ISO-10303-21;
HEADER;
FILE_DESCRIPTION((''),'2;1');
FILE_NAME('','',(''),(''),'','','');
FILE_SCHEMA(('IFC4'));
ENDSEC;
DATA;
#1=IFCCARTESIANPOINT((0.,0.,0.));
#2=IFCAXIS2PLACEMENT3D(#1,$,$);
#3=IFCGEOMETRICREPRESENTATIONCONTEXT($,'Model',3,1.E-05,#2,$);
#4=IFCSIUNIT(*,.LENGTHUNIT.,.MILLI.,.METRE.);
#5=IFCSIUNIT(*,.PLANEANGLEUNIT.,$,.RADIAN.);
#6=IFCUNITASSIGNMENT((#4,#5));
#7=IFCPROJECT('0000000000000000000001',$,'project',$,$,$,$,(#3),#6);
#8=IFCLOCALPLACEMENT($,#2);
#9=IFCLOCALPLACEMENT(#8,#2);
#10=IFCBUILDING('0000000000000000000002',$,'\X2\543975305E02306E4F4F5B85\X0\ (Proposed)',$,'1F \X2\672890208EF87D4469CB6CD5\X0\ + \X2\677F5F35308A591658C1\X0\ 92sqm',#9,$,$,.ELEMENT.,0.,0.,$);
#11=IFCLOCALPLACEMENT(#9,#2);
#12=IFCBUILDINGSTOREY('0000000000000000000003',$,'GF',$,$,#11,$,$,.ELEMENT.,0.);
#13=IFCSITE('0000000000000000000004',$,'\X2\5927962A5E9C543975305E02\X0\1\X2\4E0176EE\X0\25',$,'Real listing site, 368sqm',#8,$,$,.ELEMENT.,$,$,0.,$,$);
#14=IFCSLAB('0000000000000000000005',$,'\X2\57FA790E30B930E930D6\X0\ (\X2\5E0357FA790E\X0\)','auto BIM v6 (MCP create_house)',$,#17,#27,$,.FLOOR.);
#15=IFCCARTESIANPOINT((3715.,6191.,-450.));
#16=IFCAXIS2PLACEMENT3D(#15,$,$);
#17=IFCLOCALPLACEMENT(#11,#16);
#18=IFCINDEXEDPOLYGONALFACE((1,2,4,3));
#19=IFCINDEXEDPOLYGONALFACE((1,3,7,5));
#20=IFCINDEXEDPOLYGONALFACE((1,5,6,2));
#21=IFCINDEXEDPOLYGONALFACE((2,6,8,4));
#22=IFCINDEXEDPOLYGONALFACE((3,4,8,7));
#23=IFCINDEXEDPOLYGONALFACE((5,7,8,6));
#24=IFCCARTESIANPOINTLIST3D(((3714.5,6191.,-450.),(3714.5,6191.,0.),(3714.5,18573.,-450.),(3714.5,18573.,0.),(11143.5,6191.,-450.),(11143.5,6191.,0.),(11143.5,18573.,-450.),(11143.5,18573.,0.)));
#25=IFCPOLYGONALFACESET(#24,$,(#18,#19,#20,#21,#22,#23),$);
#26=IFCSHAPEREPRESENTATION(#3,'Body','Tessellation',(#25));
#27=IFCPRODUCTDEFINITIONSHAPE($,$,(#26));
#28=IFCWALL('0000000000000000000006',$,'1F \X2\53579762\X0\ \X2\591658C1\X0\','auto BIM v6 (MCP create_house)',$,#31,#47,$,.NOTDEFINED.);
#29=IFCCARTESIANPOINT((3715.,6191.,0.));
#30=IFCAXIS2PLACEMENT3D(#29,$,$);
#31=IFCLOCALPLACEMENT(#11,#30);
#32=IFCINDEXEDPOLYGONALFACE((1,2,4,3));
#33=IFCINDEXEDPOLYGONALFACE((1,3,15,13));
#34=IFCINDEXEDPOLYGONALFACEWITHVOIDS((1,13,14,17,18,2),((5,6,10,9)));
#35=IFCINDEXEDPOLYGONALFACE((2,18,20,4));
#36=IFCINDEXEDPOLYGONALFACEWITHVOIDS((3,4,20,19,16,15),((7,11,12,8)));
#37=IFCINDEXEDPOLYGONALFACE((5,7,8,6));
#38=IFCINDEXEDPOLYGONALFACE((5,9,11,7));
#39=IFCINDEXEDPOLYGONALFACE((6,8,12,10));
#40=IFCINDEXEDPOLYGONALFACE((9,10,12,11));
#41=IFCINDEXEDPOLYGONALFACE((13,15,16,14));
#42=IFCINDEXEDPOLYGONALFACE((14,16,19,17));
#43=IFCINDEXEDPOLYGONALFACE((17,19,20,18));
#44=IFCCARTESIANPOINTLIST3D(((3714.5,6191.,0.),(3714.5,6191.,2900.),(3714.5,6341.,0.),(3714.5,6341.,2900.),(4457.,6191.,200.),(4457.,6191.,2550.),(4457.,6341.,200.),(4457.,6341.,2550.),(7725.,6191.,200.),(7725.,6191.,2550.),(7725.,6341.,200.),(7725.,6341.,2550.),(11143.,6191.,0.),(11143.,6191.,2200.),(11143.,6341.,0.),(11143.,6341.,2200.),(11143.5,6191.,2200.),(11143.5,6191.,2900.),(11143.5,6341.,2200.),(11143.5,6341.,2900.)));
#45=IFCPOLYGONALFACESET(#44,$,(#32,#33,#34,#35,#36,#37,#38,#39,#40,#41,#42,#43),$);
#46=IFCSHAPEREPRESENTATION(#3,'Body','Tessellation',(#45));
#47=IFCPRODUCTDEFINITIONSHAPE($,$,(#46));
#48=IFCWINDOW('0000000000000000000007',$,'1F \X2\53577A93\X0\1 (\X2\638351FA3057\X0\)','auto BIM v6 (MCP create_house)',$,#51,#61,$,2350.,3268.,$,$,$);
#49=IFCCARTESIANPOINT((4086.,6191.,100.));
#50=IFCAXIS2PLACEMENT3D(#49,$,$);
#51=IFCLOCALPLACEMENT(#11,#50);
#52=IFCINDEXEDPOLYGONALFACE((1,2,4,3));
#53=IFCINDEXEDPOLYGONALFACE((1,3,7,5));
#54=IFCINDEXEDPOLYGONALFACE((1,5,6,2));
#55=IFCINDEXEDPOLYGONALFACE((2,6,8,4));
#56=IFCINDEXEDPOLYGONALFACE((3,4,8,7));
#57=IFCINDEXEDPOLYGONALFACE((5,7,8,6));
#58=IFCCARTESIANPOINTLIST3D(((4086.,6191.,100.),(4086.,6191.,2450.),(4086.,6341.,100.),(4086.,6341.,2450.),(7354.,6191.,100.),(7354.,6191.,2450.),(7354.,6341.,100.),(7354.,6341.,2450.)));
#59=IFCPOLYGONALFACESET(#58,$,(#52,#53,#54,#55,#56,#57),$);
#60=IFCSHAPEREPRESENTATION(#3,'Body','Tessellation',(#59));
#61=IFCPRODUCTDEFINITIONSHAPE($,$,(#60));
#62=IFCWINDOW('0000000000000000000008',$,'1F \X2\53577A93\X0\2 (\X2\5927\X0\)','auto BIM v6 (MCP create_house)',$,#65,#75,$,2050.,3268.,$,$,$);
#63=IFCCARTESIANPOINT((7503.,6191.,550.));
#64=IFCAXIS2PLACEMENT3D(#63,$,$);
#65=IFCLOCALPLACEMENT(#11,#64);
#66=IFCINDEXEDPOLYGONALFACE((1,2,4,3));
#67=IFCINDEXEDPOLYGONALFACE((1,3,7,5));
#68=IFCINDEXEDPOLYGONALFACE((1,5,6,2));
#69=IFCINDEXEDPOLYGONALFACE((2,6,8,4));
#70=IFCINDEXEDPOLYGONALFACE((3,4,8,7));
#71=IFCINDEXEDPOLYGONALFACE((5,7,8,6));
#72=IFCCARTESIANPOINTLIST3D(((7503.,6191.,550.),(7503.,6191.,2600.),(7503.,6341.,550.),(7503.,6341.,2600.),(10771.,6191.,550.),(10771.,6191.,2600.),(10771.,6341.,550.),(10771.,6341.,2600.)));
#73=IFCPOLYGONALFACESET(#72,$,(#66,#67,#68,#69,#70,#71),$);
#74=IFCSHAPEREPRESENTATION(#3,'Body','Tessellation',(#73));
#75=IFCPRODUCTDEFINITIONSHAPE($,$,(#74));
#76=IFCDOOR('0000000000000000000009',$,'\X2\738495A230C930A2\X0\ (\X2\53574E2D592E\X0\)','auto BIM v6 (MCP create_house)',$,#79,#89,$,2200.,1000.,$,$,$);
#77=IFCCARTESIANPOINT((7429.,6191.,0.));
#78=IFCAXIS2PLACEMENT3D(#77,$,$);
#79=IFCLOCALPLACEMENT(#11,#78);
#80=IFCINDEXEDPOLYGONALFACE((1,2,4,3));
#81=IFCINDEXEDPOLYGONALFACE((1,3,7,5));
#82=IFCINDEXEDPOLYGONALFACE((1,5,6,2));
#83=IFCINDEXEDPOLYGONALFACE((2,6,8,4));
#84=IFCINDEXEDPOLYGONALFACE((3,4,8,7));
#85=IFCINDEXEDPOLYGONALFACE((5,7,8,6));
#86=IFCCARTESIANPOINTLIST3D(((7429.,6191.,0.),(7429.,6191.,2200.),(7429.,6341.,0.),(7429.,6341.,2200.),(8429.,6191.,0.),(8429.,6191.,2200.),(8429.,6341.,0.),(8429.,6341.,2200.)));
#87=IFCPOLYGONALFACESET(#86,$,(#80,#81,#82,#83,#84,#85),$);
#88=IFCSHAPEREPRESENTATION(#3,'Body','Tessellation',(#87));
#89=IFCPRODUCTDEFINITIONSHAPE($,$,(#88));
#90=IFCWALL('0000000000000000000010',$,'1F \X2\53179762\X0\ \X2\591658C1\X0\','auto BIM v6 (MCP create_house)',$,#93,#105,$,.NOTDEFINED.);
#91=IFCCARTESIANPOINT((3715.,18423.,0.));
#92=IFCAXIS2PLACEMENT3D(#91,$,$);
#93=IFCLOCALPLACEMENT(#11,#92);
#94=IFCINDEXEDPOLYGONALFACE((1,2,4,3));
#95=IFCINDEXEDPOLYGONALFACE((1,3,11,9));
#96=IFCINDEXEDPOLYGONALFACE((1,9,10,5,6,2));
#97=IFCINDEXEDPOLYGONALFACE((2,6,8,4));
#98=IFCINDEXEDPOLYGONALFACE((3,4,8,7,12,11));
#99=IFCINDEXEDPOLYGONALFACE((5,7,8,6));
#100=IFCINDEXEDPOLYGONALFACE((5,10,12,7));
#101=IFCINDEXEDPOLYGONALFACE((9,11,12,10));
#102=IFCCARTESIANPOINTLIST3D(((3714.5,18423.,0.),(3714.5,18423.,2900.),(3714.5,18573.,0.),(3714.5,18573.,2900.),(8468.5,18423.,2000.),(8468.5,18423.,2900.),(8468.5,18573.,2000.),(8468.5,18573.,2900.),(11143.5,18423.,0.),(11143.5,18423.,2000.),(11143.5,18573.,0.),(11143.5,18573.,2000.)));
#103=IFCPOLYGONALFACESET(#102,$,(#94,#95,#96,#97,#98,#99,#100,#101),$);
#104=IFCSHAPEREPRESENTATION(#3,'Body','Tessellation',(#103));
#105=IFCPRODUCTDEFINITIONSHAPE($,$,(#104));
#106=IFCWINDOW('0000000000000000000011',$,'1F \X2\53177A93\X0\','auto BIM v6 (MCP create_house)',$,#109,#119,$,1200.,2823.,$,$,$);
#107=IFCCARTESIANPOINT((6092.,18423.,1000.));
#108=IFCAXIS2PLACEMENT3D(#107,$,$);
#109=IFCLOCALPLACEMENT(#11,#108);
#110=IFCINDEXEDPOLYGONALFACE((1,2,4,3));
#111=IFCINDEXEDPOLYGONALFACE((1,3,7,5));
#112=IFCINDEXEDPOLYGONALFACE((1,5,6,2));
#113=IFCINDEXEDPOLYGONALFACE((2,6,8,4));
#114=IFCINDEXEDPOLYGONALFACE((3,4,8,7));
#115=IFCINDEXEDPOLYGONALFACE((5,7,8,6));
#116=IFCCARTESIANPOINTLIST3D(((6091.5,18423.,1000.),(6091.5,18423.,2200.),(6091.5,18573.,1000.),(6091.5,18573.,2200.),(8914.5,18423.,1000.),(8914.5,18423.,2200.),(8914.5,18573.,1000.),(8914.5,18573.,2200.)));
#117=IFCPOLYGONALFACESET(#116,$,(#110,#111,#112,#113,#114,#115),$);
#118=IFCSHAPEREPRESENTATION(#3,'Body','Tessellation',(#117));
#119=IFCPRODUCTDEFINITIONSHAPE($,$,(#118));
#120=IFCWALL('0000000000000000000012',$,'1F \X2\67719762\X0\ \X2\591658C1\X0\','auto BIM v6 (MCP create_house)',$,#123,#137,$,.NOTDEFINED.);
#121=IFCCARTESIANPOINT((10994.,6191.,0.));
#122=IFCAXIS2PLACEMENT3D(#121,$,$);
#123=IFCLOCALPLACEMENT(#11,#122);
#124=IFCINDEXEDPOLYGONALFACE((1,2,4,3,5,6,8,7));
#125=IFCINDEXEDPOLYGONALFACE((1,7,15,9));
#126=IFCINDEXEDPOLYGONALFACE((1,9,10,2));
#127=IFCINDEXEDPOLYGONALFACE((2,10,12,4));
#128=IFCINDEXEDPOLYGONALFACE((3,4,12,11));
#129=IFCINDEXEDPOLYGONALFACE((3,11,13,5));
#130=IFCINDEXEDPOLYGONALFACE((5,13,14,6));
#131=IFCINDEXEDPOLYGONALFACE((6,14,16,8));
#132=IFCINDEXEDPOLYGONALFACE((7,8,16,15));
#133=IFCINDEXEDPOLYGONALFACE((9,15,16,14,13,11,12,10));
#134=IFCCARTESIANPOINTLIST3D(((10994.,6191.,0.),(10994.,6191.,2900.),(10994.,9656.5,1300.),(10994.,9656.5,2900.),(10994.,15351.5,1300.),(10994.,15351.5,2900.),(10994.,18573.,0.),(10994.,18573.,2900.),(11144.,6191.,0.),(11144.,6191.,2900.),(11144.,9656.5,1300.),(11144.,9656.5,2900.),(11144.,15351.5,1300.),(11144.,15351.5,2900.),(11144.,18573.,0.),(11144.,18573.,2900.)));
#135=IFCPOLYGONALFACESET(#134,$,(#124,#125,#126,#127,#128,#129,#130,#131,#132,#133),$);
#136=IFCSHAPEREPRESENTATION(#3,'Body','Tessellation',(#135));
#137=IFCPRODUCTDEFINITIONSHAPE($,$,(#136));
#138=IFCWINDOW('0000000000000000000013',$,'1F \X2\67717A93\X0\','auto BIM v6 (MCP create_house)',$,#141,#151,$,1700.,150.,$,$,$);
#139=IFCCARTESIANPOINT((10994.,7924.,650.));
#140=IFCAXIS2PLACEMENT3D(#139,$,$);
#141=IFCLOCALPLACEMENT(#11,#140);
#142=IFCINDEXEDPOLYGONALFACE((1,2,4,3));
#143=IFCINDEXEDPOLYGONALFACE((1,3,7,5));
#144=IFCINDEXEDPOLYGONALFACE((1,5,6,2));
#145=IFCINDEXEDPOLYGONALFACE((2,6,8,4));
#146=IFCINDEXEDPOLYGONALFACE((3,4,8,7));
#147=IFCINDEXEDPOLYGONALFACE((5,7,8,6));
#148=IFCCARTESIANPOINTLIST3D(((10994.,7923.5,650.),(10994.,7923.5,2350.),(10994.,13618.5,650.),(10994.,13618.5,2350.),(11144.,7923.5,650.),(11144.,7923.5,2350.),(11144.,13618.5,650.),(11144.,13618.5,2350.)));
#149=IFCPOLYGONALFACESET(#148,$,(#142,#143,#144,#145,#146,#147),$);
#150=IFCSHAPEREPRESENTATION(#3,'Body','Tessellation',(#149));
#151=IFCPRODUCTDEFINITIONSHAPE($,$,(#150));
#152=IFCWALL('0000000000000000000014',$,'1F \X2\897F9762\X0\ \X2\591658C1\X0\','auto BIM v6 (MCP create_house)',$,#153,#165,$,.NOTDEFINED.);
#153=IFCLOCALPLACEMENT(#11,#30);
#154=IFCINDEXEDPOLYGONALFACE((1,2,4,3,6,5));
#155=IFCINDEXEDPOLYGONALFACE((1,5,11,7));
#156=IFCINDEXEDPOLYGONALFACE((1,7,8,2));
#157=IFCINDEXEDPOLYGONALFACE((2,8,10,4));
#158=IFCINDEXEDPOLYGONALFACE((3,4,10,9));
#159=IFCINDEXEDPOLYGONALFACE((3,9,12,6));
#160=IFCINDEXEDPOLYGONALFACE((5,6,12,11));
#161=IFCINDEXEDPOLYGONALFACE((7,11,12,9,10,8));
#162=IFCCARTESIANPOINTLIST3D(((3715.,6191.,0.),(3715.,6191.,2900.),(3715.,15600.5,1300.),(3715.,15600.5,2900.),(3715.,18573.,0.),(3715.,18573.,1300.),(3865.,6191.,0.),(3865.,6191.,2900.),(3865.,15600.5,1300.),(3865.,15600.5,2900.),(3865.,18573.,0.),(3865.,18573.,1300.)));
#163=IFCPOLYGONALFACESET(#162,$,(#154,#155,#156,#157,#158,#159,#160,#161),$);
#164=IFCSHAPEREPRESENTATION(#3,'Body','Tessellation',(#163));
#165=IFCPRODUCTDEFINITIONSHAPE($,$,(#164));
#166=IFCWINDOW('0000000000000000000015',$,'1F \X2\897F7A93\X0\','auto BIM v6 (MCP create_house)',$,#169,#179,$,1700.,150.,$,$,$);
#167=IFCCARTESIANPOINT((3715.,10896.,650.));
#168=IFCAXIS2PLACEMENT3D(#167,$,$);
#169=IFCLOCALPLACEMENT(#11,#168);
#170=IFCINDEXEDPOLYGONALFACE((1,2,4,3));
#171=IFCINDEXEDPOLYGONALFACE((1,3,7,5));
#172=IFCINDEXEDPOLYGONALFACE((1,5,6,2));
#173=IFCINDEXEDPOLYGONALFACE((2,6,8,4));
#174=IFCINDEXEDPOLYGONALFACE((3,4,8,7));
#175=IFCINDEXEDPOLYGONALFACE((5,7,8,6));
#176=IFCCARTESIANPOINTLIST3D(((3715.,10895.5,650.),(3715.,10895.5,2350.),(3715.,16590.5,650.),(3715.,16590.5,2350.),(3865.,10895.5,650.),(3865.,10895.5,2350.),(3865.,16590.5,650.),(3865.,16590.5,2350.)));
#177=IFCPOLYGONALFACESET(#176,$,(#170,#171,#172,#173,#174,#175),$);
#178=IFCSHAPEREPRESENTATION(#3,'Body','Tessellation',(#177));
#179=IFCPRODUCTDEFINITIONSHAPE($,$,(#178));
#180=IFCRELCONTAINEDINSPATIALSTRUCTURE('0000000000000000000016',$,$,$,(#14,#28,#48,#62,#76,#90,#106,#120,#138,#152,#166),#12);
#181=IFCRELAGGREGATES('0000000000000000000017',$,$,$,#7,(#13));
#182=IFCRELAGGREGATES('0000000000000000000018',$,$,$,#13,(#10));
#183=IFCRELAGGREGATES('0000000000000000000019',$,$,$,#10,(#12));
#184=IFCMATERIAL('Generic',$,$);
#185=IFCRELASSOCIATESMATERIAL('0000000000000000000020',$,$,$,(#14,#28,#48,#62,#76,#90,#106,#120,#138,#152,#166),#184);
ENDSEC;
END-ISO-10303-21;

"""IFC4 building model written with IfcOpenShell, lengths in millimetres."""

from ifc_helpers import new_model, si_unit, frame, frame_2d, origin, place, context, project, spatial, rectangle, extrude, material, element, fill, save


model = new_model("IFC4")

# Units and contexts
model_context = context("Model", 3, precision=1e-05, world=origin())
ifc_project = project(units=[si_unit("LENGTHUNIT", "METRE", prefix="MILLI"), si_unit("PLANEANGLEUNIT", "RADIAN")], contexts=[model_context])

# Site, building, storey
site_placement = place(None, origin())
site = spatial("IfcSite", under=ifc_project, at=site_placement, Name="大阪府吹田市1丁目25", ObjectType="Real listing site, 368sqm", CompositionType="ELEMENT", RefElevation=0.0)
building_placement = place(site_placement, origin())
building = spatial("IfcBuilding", under=site, at=building_placement, Name="吹田市の住宅 (Proposed)", ObjectType="1F 木造軸組構法 + 板張り外壁 92sqm", CompositionType="ELEMENT", ElevationOfRefHeight=0.0, ElevationOfTerrain=0.0)
storey_placement = place(building_placement, origin())
storey = spatial("IfcBuildingStorey", under=building, at=storey_placement, Name="GF", CompositionType="ELEMENT", Elevation=0.0)

# Slab
ifc_material = material(Name="Generic")
slab_1_placement = place(storey_placement, frame((3715.0, 6191.0, -450.0)))
element("IfcSlab", 1, at=slab_1_placement, inside=storey, material=ifc_material, Name="基礎スラブ (布基礎)", Description="auto BIM v6 (MCP create_house)", PredefinedType="FLOOR", context=model_context, shape_type="SweptSolid", body=[
    extrude(rectangle(XDim=7429.0, YDim=12382.0, at=frame_2d((3714.0, 6191.0))), frame((3715.0, 6191.0, -450.0)), (0.0, 0.0, 1.0), 450.0),
])

# Wall, openings, windows, door
wall_1_placement = place(storey_placement, frame((3715.0, 6191.0, 0.0)))
wall_1 = element("IfcWall", 2, at=wall_1_placement, inside=storey, material=ifc_material, Name="1F 南面 外壁", Description="auto BIM v6 (MCP create_house)", PredefinedType="NOTDEFINED", context=model_context, shape_type="SweptSolid", body=[
    extrude(rectangle(XDim=7429.0, YDim=150.0, at=frame_2d((3714.0, 75.0))), frame((3715.0, 6191.0, 0.0)), (0.0, 0.0, 1.0), 2900.0),
])
opening_1_placement = place(storey_placement, frame((4086.0, 6191.0, 100.0)))
opening_1 = element("IfcOpeningElement", 3, at=opening_1_placement, cuts=wall_1, PredefinedType="NOTDEFINED", context=model_context, shape_type="SweptSolid", body=[
    extrude(rectangle(XDim=3268.0, YDim=150.0, at=frame_2d((1634.0, 75.0))), frame((4086.0, 6191.0, 100.0)), (0.0, 0.0, 1.0), 2350.0),
])
opening_2_placement = place(storey_placement, frame((7503.0, 6191.0, 550.0)))
opening_2 = element("IfcOpeningElement", 4, at=opening_2_placement, cuts=wall_1, PredefinedType="NOTDEFINED", context=model_context, shape_type="SweptSolid", body=[
    extrude(rectangle(XDim=3268.0, YDim=150.0, at=frame_2d((1634.0, 75.0))), frame((7503.0, 6191.0, 550.0)), (0.0, 0.0, 1.0), 2050.0),
])
opening_3_placement = place(storey_placement, frame((7429.0, 6191.0, 0.0)))
opening_3 = element("IfcOpeningElement", 5, at=opening_3_placement, cuts=wall_1, PredefinedType="NOTDEFINED", context=model_context, shape_type="SweptSolid", body=[
    extrude(rectangle(XDim=1000.0, YDim=150.0, at=frame_2d((500.0, 75.0))), frame((7429.0, 6191.0, 0.0)), (0.0, 0.0, 1.0), 2200.0),
])
window_1_placement = place(storey_placement, frame((4086.0, 6191.0, 100.0)))
window_1 = element("IfcWindow", 6, at=window_1_placement, inside=storey, material=ifc_material, Name="1F 南窓1 (掃出し)", Description="auto BIM v6 (MCP create_house)", OverallHeight=2350.0, OverallWidth=3268.0, context=model_context, shape_type="SweptSolid", body=[
    extrude(rectangle(XDim=3268.0, YDim=150.0, at=frame_2d((1634.0, 75.0))), frame((4086.0, 6191.0, 100.0)), (0.0, 0.0, 1.0), 2350.0),
])
fill(opening_1, window_1)
window_2_placement = place(storey_placement, frame((7503.0, 6191.0, 550.0)))
window_2 = element("IfcWindow", 7, at=window_2_placement, inside=storey, material=ifc_material, Name="1F 南窓2 (大)", Description="auto BIM v6 (MCP create_house)", OverallHeight=2050.0, OverallWidth=3268.0, context=model_context, shape_type="SweptSolid", body=[
    extrude(rectangle(XDim=3268.0, YDim=150.0, at=frame_2d((1634.0, 75.0))), frame((7503.0, 6191.0, 550.0)), (0.0, 0.0, 1.0), 2050.0),
])
fill(opening_2, window_2)
door_placement = place(storey_placement, frame((7429.0, 6191.0, 0.0)))
door = element("IfcDoor", 8, at=door_placement, inside=storey, material=ifc_material, Name="玄関ドア (南中央)", Description="auto BIM v6 (MCP create_house)", OverallHeight=2200.0, OverallWidth=1000.0, context=model_context, shape_type="SweptSolid", body=[
    extrude(rectangle(XDim=1000.0, YDim=150.0, at=frame_2d((500.0, 75.0))), frame((7429.0, 6191.0, 0.0)), (0.0, 0.0, 1.0), 2200.0),
])
fill(opening_3, door)

# Walls, openings, windows
wall_2_placement = place(storey_placement, frame((3715.0, 18423.0, 0.0)))
wall_2 = element("IfcWall", 9, at=wall_2_placement, inside=storey, material=ifc_material, Name="1F 北面 外壁", Description="auto BIM v6 (MCP create_house)", PredefinedType="NOTDEFINED", context=model_context, shape_type="SweptSolid", body=[
    extrude(rectangle(XDim=7429.0, YDim=150.0, at=frame_2d((3714.0, 75.0))), frame((3715.0, 18423.0, 0.0)), (0.0, 0.0, 1.0), 2900.0),
])
opening_4_placement = place(storey_placement, frame((6092.0, 18423.0, 1000.0)))
opening_4 = element("IfcOpeningElement", 10, at=opening_4_placement, cuts=wall_2, PredefinedType="NOTDEFINED", context=model_context, shape_type="SweptSolid", body=[
    extrude(rectangle(XDim=2823.0, YDim=150.0, at=frame_2d((1411.0, 75.0))), frame((6092.0, 18423.0, 1000.0)), (0.0, 0.0, 1.0), 1200.0),
])
window_3_placement = place(storey_placement, frame((6092.0, 18423.0, 1000.0)))
window_3 = element("IfcWindow", 11, at=window_3_placement, inside=storey, material=ifc_material, Name="1F 北窓", Description="auto BIM v6 (MCP create_house)", OverallHeight=1200.0, OverallWidth=2823.0, context=model_context, shape_type="SweptSolid", body=[
    extrude(rectangle(XDim=2823.0, YDim=150.0, at=frame_2d((1411.0, 75.0))), frame((6092.0, 18423.0, 1000.0)), (0.0, 0.0, 1.0), 1200.0),
])
fill(opening_4, window_3)
wall_3_placement = place(storey_placement, frame((10994.0, 6191.0, 0.0)))
wall_3 = element("IfcWall", 12, at=wall_3_placement, inside=storey, material=ifc_material, Name="1F 東面 外壁", Description="auto BIM v6 (MCP create_house)", PredefinedType="NOTDEFINED", context=model_context, shape_type="SweptSolid", body=[
    extrude(rectangle(XDim=150.0, YDim=12382.0, at=frame_2d((75.0, 6191.0))), frame((10994.0, 6191.0, 0.0)), (0.0, 0.0, 1.0), 2900.0),
])
opening_5_placement = place(storey_placement, frame((10994.0, 7924.0, 650.0)))
opening_5 = element("IfcOpeningElement", 13, at=opening_5_placement, cuts=wall_3, PredefinedType="NOTDEFINED", context=model_context, shape_type="SweptSolid", body=[
    extrude(rectangle(XDim=150.0, YDim=5695.0, at=frame_2d((75.0, 2847.0))), frame((10994.0, 7924.0, 650.0)), (0.0, 0.0, 1.0), 1700.0),
])
window_4_placement = place(storey_placement, frame((10994.0, 7924.0, 650.0)))
window_4 = element("IfcWindow", 14, at=window_4_placement, inside=storey, material=ifc_material, Name="1F 東窓", Description="auto BIM v6 (MCP create_house)", OverallHeight=1700.0, OverallWidth=150.0, context=model_context, shape_type="SweptSolid", body=[
    extrude(rectangle(XDim=150.0, YDim=5695.0, at=frame_2d((75.0, 2847.0))), frame((10994.0, 7924.0, 650.0)), (0.0, 0.0, 1.0), 1700.0),
])
fill(opening_5, window_4)
wall_4_placement = place(storey_placement, frame((3715.0, 6191.0, 0.0)))
wall_4 = element("IfcWall", 15, at=wall_4_placement, inside=storey, material=ifc_material, Name="1F 西面 外壁", Description="auto BIM v6 (MCP create_house)", PredefinedType="NOTDEFINED", context=model_context, shape_type="SweptSolid", body=[
    extrude(rectangle(XDim=150.0, YDim=12382.0, at=frame_2d((75.0, 6191.0))), frame((3715.0, 6191.0, 0.0)), (0.0, 0.0, 1.0), 2900.0),
])
opening_6_placement = place(storey_placement, frame((3715.0, 10896.0, 650.0)))
opening_6 = element("IfcOpeningElement", 16, at=opening_6_placement, cuts=wall_4, PredefinedType="NOTDEFINED", context=model_context, shape_type="SweptSolid", body=[
    extrude(rectangle(XDim=150.0, YDim=5695.0, at=frame_2d((75.0, 2847.0))), frame((3715.0, 10896.0, 650.0)), (0.0, 0.0, 1.0), 1700.0),
])
window_5_placement = place(storey_placement, frame((3715.0, 10896.0, 650.0)))
window_5 = element("IfcWindow", 17, at=window_5_placement, inside=storey, material=ifc_material, Name="1F 西窓", Description="auto BIM v6 (MCP create_house)", OverallHeight=1700.0, OverallWidth=150.0, context=model_context, shape_type="SweptSolid", body=[
    extrude(rectangle(XDim=150.0, YDim=5695.0, at=frame_2d((75.0, 2847.0))), frame((3715.0, 10896.0, 650.0)), (0.0, 0.0, 1.0), 1700.0),
])
fill(opening_6, window_5)

save(model, "model.ifc")
